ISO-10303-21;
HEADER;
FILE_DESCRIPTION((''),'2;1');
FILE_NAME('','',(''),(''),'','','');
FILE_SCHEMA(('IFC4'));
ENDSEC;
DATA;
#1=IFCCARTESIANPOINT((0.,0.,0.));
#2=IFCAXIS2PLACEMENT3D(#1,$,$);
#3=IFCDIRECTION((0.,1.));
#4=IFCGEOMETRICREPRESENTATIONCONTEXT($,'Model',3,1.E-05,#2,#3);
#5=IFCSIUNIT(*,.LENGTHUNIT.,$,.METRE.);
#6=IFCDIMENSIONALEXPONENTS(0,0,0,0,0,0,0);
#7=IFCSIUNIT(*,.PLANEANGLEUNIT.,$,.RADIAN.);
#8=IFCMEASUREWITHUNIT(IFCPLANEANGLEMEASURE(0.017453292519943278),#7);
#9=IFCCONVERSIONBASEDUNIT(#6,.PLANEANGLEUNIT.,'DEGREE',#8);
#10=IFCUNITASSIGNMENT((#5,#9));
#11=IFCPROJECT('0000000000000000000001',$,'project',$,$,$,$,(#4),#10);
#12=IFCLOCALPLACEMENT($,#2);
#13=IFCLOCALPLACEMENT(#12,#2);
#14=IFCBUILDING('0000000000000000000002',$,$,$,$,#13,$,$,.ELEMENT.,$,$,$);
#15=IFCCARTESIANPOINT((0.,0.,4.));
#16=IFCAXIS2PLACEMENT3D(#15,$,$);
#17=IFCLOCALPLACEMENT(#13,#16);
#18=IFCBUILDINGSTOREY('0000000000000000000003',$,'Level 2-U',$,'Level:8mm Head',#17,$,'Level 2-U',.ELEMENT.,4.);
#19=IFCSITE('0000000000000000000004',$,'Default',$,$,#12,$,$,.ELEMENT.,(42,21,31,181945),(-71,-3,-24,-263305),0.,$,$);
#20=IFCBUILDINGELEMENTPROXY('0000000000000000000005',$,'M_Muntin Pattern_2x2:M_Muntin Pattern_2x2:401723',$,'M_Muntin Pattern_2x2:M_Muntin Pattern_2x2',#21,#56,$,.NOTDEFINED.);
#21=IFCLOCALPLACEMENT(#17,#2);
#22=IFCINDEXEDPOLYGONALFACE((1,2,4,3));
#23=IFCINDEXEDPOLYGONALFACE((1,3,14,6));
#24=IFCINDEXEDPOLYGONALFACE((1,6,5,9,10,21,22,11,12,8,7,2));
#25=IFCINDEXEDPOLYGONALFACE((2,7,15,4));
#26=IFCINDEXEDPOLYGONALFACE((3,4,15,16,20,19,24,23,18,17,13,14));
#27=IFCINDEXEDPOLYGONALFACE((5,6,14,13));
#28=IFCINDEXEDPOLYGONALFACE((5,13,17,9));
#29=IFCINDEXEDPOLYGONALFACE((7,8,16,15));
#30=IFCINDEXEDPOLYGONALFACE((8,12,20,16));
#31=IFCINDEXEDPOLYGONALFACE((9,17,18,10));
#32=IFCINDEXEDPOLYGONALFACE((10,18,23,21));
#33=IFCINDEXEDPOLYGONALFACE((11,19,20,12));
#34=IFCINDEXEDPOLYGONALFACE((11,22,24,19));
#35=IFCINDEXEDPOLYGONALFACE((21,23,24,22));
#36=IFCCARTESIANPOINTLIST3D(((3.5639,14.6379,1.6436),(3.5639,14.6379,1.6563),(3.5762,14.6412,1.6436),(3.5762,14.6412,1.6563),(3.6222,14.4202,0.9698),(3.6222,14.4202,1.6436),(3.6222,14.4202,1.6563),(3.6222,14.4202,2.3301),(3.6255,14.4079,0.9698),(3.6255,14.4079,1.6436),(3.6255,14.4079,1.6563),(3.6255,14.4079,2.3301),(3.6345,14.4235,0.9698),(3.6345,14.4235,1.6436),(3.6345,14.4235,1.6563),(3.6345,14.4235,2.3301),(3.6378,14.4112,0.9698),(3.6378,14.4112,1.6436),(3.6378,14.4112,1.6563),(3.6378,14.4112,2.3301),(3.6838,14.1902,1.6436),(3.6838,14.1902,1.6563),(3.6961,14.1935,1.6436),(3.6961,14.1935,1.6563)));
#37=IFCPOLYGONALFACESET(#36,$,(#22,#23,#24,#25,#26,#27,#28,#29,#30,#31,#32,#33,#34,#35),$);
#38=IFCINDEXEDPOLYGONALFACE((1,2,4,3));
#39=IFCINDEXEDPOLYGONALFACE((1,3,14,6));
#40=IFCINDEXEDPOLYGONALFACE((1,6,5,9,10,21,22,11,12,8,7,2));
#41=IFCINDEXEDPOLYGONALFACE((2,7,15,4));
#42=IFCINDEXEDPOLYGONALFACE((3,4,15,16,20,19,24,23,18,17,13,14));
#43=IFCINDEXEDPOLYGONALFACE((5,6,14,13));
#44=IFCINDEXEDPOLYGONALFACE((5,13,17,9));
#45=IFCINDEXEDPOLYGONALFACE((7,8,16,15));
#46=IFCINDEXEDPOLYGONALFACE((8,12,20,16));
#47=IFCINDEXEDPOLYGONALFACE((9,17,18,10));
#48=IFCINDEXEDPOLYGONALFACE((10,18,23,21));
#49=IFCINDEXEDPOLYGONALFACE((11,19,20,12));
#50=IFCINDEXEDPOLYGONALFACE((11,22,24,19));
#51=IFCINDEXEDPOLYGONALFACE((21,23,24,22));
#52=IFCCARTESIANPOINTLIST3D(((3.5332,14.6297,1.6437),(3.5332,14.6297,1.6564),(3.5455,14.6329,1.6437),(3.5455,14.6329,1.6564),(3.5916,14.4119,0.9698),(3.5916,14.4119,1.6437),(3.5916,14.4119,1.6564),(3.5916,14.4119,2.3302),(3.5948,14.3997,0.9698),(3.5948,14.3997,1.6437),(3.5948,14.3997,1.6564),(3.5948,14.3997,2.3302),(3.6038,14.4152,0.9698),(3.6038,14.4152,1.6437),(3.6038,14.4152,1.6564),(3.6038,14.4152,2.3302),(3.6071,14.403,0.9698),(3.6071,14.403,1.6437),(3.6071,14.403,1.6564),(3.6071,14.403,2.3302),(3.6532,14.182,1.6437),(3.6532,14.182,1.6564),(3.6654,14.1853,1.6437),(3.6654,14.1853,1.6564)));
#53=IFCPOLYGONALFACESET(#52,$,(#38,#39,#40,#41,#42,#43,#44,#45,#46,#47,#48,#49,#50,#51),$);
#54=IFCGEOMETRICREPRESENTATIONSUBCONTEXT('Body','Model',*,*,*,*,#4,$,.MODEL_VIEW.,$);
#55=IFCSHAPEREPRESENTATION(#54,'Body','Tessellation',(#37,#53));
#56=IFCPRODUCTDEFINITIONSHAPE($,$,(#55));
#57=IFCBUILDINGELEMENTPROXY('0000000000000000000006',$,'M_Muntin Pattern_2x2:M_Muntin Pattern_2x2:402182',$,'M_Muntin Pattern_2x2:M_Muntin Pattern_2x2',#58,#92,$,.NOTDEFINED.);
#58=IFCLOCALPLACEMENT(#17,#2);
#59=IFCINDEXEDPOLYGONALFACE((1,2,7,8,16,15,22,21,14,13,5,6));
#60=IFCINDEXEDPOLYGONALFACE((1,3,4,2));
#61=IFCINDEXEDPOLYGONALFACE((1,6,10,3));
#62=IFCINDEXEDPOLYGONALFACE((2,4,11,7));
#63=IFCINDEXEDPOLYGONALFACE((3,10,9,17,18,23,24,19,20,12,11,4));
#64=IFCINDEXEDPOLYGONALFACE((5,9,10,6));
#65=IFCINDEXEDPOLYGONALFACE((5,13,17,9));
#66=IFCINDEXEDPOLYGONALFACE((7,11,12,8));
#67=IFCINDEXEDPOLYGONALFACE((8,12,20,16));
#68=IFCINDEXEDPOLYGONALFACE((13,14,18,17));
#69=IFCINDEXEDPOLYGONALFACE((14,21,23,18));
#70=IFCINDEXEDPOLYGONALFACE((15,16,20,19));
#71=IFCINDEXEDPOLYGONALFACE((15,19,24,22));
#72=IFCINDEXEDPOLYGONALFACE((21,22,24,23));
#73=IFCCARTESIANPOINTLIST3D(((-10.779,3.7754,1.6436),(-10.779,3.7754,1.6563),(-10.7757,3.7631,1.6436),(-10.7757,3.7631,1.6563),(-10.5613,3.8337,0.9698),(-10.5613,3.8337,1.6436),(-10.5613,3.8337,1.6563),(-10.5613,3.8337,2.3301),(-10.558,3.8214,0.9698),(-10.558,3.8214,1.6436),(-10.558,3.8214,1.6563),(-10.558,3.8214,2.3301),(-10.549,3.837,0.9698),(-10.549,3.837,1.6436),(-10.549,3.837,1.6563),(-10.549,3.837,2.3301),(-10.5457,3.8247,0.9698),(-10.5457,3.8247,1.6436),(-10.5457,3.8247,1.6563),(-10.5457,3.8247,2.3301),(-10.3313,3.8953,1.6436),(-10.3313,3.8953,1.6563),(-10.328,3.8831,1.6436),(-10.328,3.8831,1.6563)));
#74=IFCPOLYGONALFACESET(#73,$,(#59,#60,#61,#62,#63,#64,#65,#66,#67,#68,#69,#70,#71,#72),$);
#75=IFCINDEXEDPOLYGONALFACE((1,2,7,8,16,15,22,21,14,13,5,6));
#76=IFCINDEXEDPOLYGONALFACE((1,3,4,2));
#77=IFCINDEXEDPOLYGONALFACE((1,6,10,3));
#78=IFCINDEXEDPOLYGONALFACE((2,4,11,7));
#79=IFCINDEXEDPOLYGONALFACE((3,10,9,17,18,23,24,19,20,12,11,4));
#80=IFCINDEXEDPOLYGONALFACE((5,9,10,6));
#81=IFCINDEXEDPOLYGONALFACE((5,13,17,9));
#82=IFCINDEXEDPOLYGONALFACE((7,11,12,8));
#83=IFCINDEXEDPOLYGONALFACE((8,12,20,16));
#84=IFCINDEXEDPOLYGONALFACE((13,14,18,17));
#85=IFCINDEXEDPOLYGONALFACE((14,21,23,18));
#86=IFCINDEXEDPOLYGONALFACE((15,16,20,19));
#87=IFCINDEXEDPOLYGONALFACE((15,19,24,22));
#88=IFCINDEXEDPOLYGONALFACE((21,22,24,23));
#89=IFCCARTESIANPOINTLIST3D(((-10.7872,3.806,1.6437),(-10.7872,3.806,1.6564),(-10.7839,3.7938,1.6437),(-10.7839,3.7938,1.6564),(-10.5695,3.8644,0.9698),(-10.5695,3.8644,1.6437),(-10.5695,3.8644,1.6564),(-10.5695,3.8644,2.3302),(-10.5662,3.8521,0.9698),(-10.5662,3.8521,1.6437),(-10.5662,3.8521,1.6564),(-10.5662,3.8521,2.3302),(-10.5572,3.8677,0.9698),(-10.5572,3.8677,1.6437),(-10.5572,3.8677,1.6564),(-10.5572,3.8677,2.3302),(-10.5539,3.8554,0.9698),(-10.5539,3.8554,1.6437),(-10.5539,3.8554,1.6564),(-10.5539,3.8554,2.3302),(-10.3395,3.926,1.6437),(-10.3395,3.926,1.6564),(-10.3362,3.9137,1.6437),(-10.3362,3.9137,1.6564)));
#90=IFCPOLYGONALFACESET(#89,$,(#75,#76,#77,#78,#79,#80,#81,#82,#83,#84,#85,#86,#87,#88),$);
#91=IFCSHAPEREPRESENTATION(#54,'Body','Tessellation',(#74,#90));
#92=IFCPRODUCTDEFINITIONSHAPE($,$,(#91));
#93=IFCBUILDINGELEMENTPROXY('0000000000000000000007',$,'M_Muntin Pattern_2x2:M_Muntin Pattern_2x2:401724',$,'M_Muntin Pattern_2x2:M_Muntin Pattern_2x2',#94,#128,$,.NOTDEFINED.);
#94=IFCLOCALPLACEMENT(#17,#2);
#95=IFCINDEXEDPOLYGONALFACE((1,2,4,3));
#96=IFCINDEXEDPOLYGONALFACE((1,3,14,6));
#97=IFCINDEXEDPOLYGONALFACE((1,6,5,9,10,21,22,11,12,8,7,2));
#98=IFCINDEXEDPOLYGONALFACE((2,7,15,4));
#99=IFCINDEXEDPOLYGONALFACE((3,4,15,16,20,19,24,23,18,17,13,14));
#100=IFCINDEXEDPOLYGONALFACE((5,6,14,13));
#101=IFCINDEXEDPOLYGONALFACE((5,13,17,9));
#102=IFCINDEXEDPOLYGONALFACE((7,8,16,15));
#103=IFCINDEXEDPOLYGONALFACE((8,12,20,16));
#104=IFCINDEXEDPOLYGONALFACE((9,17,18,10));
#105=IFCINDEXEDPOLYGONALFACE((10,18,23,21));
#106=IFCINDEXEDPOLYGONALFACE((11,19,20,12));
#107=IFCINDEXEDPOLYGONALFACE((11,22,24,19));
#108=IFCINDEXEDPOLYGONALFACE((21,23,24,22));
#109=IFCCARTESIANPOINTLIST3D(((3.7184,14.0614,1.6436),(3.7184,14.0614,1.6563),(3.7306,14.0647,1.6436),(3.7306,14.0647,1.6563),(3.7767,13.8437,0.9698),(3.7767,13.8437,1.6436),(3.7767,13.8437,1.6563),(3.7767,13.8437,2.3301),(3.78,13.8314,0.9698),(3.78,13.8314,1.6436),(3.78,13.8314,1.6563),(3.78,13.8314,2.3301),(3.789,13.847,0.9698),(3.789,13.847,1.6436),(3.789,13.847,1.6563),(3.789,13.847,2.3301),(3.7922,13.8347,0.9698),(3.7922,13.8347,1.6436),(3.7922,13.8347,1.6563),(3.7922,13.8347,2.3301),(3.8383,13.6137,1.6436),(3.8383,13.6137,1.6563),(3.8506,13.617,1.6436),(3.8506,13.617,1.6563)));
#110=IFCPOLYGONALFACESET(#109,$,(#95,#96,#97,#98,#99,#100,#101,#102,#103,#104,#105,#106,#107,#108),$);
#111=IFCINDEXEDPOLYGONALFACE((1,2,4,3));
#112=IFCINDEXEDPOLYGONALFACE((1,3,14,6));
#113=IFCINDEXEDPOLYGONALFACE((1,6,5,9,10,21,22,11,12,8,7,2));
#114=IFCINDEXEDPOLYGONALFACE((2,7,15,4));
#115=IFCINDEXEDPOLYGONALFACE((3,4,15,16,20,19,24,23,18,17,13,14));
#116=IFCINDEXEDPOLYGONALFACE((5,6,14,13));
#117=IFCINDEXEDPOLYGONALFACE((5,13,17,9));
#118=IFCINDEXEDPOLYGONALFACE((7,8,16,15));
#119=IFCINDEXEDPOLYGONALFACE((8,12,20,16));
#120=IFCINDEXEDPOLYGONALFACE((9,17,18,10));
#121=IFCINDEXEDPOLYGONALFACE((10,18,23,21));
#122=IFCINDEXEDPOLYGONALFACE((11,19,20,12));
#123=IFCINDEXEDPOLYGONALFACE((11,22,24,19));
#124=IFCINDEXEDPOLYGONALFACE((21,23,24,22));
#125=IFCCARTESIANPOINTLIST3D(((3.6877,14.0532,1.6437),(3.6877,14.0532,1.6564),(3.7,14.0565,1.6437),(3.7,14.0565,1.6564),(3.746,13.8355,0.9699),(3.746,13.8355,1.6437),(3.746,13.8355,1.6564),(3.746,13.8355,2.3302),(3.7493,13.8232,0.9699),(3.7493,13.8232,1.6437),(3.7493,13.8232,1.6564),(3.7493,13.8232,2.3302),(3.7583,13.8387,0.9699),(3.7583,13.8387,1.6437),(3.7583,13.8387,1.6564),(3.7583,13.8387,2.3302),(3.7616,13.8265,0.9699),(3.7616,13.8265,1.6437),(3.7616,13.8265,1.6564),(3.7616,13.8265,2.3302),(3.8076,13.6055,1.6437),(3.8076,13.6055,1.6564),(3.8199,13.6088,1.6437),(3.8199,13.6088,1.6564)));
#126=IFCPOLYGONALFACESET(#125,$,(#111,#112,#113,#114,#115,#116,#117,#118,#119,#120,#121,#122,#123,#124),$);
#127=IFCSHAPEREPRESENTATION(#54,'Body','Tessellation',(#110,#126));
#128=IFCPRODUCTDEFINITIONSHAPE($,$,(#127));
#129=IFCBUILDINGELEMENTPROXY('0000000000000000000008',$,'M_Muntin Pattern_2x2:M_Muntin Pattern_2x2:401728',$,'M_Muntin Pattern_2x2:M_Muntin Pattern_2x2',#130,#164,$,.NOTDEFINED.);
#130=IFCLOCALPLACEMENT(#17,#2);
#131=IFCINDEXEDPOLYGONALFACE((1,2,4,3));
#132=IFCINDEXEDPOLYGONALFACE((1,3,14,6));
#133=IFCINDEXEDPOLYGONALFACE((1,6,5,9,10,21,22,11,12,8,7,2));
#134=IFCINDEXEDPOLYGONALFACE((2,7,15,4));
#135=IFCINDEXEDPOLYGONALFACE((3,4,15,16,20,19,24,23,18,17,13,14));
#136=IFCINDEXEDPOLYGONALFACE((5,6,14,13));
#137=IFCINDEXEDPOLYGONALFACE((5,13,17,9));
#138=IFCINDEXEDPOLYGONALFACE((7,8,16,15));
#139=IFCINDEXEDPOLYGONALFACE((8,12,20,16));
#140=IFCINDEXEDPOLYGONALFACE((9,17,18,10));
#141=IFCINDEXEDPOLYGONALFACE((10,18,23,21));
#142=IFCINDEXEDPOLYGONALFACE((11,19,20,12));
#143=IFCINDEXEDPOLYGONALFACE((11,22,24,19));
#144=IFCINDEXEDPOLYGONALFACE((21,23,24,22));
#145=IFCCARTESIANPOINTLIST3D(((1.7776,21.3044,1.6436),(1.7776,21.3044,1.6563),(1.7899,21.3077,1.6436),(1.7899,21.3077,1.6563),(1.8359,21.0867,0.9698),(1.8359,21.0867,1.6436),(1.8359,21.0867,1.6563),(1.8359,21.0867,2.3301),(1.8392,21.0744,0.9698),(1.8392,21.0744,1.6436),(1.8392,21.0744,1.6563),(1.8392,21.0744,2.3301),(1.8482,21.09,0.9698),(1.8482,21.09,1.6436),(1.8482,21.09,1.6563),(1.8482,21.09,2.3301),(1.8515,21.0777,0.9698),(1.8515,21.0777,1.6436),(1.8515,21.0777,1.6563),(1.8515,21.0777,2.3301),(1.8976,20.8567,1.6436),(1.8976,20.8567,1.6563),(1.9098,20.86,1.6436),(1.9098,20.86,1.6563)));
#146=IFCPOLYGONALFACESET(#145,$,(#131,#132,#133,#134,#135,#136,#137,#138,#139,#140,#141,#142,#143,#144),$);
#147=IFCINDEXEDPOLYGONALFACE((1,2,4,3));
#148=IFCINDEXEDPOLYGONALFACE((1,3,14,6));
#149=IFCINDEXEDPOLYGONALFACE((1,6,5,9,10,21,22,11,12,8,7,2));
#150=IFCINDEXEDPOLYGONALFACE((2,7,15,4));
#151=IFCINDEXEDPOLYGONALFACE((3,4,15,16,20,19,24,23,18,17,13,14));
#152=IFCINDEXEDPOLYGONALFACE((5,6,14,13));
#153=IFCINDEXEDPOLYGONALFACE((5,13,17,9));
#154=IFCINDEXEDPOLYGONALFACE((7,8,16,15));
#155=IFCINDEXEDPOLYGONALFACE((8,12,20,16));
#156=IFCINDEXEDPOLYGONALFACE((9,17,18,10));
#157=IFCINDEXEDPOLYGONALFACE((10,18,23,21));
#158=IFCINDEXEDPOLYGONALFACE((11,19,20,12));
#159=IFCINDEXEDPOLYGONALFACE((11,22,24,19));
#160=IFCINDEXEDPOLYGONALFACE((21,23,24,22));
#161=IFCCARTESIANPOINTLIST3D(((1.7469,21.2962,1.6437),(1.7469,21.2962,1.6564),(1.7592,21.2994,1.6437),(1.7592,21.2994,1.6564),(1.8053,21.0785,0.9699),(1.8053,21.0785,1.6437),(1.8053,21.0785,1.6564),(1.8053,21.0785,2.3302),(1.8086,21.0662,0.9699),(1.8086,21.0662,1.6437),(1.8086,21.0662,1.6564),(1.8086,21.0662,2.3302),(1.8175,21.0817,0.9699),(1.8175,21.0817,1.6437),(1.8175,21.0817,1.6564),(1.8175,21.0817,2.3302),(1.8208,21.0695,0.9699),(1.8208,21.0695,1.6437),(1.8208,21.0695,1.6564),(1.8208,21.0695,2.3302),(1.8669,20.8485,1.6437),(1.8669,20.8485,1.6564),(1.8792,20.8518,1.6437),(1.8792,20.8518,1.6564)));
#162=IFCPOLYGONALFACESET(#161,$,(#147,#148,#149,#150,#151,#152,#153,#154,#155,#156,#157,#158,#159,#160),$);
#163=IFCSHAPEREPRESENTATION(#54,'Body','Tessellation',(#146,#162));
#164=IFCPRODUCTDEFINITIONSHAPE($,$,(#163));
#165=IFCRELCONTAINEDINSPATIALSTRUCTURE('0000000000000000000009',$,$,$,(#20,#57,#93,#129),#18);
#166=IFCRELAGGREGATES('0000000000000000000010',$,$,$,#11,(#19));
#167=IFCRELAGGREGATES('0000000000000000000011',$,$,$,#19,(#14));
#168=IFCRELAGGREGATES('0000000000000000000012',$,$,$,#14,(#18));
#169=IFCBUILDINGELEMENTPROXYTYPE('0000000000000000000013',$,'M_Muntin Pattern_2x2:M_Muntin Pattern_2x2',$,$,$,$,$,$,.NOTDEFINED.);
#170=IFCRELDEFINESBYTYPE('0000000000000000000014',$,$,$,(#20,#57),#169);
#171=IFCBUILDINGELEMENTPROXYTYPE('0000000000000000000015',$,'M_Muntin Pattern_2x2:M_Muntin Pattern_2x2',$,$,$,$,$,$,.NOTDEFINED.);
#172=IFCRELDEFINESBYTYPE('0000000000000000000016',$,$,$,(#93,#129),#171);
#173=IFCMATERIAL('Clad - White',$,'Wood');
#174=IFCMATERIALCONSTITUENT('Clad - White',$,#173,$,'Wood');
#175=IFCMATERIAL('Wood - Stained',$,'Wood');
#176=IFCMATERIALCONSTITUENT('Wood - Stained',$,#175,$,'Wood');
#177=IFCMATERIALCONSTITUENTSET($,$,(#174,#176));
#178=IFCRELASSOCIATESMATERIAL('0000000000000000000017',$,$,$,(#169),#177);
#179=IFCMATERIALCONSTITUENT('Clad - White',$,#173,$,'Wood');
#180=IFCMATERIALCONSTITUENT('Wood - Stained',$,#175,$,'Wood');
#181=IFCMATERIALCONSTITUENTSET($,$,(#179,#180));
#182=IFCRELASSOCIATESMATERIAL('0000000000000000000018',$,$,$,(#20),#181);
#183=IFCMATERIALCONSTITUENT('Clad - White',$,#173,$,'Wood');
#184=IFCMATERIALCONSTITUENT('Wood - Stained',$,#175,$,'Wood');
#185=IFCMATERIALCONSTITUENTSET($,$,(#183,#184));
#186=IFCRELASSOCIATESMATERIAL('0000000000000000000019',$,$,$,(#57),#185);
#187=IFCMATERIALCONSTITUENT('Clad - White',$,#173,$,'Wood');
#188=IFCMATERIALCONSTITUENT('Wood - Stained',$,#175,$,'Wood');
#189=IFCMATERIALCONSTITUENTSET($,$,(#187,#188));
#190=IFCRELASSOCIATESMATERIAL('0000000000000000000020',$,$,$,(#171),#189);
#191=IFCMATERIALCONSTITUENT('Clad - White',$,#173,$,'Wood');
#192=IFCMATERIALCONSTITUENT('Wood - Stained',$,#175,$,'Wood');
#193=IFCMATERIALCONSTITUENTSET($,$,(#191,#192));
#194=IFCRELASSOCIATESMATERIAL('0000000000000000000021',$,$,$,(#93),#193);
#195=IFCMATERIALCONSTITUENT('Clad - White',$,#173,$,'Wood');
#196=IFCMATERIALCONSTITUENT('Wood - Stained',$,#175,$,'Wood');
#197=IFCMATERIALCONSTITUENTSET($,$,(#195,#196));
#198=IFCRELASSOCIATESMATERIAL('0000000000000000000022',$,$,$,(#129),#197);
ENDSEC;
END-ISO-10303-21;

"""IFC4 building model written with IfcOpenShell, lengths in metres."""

from ifc_helpers import new_model, entity, si_unit, converted_unit, direction, frame, origin, place, context, subcontext, project, spatial, indexed_curve, outline, extrude, source, transform, mapped, material, constituent, constituent_set, type_object, type_shapes, element, save


model = new_model("IFC4")

# Units and contexts
model_context = context("Model", 3, precision=1e-05, world=origin(), true_north=direction((0.0, 1.0)))
body_context = subcontext(model_context, "Body", "Model", "MODEL_VIEW")
ifc_project = project(units=[si_unit("LENGTHUNIT", "METRE"), converted_unit("PLANEANGLEUNIT", "DEGREE", entity("IfcPlaneAngleMeasure", 0.017453292519943278), si_unit("PLANEANGLEUNIT", "RADIAN"), dimensions=[0, 0, 0, 0, 0, 0, 0])], contexts=[model_context])

# Site, building, storey
site_placement = place(None, origin())
site = spatial("IfcSite", under=ifc_project, at=site_placement, Name="Default", CompositionType="ELEMENT", RefLatitude=(42, 21, 31, 181945), RefLongitude=(-71, -3, -24, -263305), RefElevation=0.0)
building_placement = place(site_placement, origin())
building = spatial("IfcBuilding", under=site, at=building_placement, CompositionType="ELEMENT")
storey_placement = place(building_placement, frame((0.0, 0.0, 4.0)))
storey = spatial("IfcBuildingStorey", under=building, at=storey_placement, Name="Level 2-U", ObjectType="Level:8mm Head", LongName="Level 2-U", CompositionType="ELEMENT", Elevation=4.0)

# Building element proxies
ifc_material_1 = material(Name="Clad - White", Category="Wood")
ifc_constituent_1 = constituent(ifc_material_1, Name="Clad - White", Category="Wood")
ifc_material_2 = material(Name="Wood - Stained", Category="Wood")
ifc_constituent_2 = constituent(ifc_material_2, Name="Wood - Stained", Category="Wood")
ifc_constituent_set_1 = constituent_set(constituents=[ifc_constituent_1, ifc_constituent_2])
ifc_constituent_3 = constituent(ifc_material_1, Name="Clad - White", Category="Wood")
ifc_constituent_4 = constituent(ifc_material_2, Name="Wood - Stained", Category="Wood")
ifc_constituent_set_2 = constituent_set(constituents=[ifc_constituent_3, ifc_constituent_4])
building_element_proxy_type_1 = type_object("IfcBuildingElementProxyType", Name="M_Muntin Pattern_2x2:M_Muntin Pattern_2x2", PredefinedType="NOTDEFINED", material=ifc_constituent_set_2)
shared_shape_1 = source(origin(), body_context, "Body", "SweptSolid", [
    extrude(outline(indexed_curve([(0.0064, -0.0064), (0.6801, -0.0064), (0.6801, 0.0063), (0.0064, 0.0063), (0.0064, 0.2317), (-0.0063, 0.2317), (-0.0063, 0.0063), (-0.6802, 0.0063), (-0.6802, -0.0064), (-0.0063, -0.0064), (-0.0063, -0.2317), (0.0064, -0.2317), (0.0064, -0.0064)], self_intersect=False)), frame((0.0, 0.0095, 0.6801), z_axis=(0.0, 1.0, 0.0), x_axis=(0.0, 0.0, 1.0)), (0.0, 0.0, 1.0), 0.0127),
    extrude(outline(indexed_curve([(0.0064, -0.0064), (0.6802, -0.0064), (0.6802, 0.0063), (0.0064, 0.0063), (0.0064, 0.2317), (-0.0063, 0.2317), (-0.0063, 0.0063), (-0.6802, 0.0063), (-0.6802, -0.0064), (-0.0063, -0.0064), (-0.0063, -0.2317), (0.0064, -0.2317), (0.0064, -0.0064)], self_intersect=False)), frame((0.0, -0.0222, 0.6802), z_axis=(0.0, 1.0, 0.0), x_axis=(0.0, 0.0, 1.0)), (0.0, 0.0, 1.0), 0.0127),
])
type_shapes(building_element_proxy_type_1, [shared_shape_1])
proxy_1_placement = place(storey_placement, frame((3.6147, 14.4116, 0.9698), z_axis=(0.0, 0.0, 1.0), x_axis=(0.258819, -0.965926, 0.0)))
element("IfcBuildingElementProxy", 1, at=proxy_1_placement, inside=storey, type_object=building_element_proxy_type_1, material=ifc_constituent_set_1, Name="M_Muntin Pattern_2x2:M_Muntin Pattern_2x2:401723", ObjectType="M_Muntin Pattern_2x2:M_Muntin Pattern_2x2", PredefinedType="NOTDEFINED", context=body_context, shape_type="MappedRepresentation", body=[
    mapped(shared_shape_1, transform((0.0, 0.0, 0.0), scale=1.0)),
])
ifc_constituent_5 = constituent(ifc_material_1, Name="Clad - White", Category="Wood")
ifc_constituent_6 = constituent(ifc_material_2, Name="Wood - Stained", Category="Wood")
ifc_constituent_set_3 = constituent_set(constituents=[ifc_constituent_5, ifc_constituent_6])
proxy_2_placement = place(storey_placement, frame((-10.5576, 3.8446, 0.9698), z_axis=(0.0, 0.0, 1.0), x_axis=(-0.965926, -0.258819, 0.0)))
element("IfcBuildingElementProxy", 2, at=proxy_2_placement, inside=storey, type_object=building_element_proxy_type_1, material=ifc_constituent_set_3, Name="M_Muntin Pattern_2x2:M_Muntin Pattern_2x2:402182", ObjectType="M_Muntin Pattern_2x2:M_Muntin Pattern_2x2", PredefinedType="NOTDEFINED", context=body_context, shape_type="MappedRepresentation", body=[
    mapped(shared_shape_1, transform((0.0, 0.0, 0.0), scale=1.0)),
])
ifc_constituent_7 = constituent(ifc_material_1, Name="Clad - White", Category="Wood")
ifc_constituent_8 = constituent(ifc_material_2, Name="Wood - Stained", Category="Wood")
ifc_constituent_set_4 = constituent_set(constituents=[ifc_constituent_7, ifc_constituent_8])
ifc_constituent_9 = constituent(ifc_material_1, Name="Clad - White", Category="Wood")
ifc_constituent_10 = constituent(ifc_material_2, Name="Wood - Stained", Category="Wood")
ifc_constituent_set_5 = constituent_set(constituents=[ifc_constituent_9, ifc_constituent_10])
building_element_proxy_type_2 = type_object("IfcBuildingElementProxyType", Name="M_Muntin Pattern_2x2:M_Muntin Pattern_2x2", PredefinedType="NOTDEFINED", material=ifc_constituent_set_5)
shared_shape_2 = source(origin(), body_context, "Body", "SweptSolid", [
    extrude(outline(indexed_curve([(0.0064, -0.0064), (0.6801, -0.0064), (0.6801, 0.0063), (0.0064, 0.0063), (0.0064, 0.2317), (-0.0063, 0.2317), (-0.0063, 0.0063), (-0.6802, 0.0063), (-0.6802, -0.0064), (-0.0063, -0.0064), (-0.0063, -0.2317), (0.0064, -0.2317), (0.0064, -0.0064)], self_intersect=False)), frame((0.0, -0.0222, 0.6801), z_axis=(0.0, 1.0, 0.0), x_axis=(0.0, 0.0, 1.0)), (0.0, 0.0, 1.0), 0.0127),
    extrude(outline(indexed_curve([(0.0064, -0.0064), (0.6802, -0.0064), (0.6802, 0.0063), (0.0064, 0.0063), (0.0064, 0.2317), (-0.0063, 0.2317), (-0.0063, 0.0063), (-0.6802, 0.0063), (-0.6802, -0.0064), (-0.0063, -0.0064), (-0.0063, -0.2317), (0.0064, -0.2317), (0.0064, -0.0064)], self_intersect=False)), frame((0.0, 0.0095, 0.6802), z_axis=(0.0, 1.0, 0.0), x_axis=(0.0, 0.0, 1.0)), (0.0, 0.0, 1.0), 0.0127),
])
type_shapes(building_element_proxy_type_2, [shared_shape_2])
proxy_3_placement = place(storey_placement, frame((3.7691, 13.8351, 0.9699), z_axis=(0.0, 0.0, 1.0), x_axis=(-0.258819, 0.965926, 0.0)))
element("IfcBuildingElementProxy", 3, at=proxy_3_placement, inside=storey, type_object=building_element_proxy_type_2, material=ifc_constituent_set_4, Name="M_Muntin Pattern_2x2:M_Muntin Pattern_2x2:401724", ObjectType="M_Muntin Pattern_2x2:M_Muntin Pattern_2x2", PredefinedType="NOTDEFINED", context=body_context, shape_type="MappedRepresentation", body=[
    mapped(shared_shape_2, transform((0.0, 0.0, 0.0), scale=1.0)),
])
ifc_constituent_11 = constituent(ifc_material_1, Name="Clad - White", Category="Wood")
ifc_constituent_12 = constituent(ifc_material_2, Name="Wood - Stained", Category="Wood")
ifc_constituent_set_6 = constituent_set(constituents=[ifc_constituent_11, ifc_constituent_12])
proxy_4_placement = place(storey_placement, frame((1.8284, 21.0781, 0.9699), z_axis=(0.0, 0.0, 1.0), x_axis=(-0.258819, 0.965926, 0.0)))
element("IfcBuildingElementProxy", 4, at=proxy_4_placement, inside=storey, type_object=building_element_proxy_type_2, material=ifc_constituent_set_6, Name="M_Muntin Pattern_2x2:M_Muntin Pattern_2x2:401728", ObjectType="M_Muntin Pattern_2x2:M_Muntin Pattern_2x2", PredefinedType="NOTDEFINED", context=body_context, shape_type="MappedRepresentation", body=[
    mapped(shared_shape_2, transform((0.0, 0.0, 0.0), scale=1.0)),
])

save(model, "model.ifc")
